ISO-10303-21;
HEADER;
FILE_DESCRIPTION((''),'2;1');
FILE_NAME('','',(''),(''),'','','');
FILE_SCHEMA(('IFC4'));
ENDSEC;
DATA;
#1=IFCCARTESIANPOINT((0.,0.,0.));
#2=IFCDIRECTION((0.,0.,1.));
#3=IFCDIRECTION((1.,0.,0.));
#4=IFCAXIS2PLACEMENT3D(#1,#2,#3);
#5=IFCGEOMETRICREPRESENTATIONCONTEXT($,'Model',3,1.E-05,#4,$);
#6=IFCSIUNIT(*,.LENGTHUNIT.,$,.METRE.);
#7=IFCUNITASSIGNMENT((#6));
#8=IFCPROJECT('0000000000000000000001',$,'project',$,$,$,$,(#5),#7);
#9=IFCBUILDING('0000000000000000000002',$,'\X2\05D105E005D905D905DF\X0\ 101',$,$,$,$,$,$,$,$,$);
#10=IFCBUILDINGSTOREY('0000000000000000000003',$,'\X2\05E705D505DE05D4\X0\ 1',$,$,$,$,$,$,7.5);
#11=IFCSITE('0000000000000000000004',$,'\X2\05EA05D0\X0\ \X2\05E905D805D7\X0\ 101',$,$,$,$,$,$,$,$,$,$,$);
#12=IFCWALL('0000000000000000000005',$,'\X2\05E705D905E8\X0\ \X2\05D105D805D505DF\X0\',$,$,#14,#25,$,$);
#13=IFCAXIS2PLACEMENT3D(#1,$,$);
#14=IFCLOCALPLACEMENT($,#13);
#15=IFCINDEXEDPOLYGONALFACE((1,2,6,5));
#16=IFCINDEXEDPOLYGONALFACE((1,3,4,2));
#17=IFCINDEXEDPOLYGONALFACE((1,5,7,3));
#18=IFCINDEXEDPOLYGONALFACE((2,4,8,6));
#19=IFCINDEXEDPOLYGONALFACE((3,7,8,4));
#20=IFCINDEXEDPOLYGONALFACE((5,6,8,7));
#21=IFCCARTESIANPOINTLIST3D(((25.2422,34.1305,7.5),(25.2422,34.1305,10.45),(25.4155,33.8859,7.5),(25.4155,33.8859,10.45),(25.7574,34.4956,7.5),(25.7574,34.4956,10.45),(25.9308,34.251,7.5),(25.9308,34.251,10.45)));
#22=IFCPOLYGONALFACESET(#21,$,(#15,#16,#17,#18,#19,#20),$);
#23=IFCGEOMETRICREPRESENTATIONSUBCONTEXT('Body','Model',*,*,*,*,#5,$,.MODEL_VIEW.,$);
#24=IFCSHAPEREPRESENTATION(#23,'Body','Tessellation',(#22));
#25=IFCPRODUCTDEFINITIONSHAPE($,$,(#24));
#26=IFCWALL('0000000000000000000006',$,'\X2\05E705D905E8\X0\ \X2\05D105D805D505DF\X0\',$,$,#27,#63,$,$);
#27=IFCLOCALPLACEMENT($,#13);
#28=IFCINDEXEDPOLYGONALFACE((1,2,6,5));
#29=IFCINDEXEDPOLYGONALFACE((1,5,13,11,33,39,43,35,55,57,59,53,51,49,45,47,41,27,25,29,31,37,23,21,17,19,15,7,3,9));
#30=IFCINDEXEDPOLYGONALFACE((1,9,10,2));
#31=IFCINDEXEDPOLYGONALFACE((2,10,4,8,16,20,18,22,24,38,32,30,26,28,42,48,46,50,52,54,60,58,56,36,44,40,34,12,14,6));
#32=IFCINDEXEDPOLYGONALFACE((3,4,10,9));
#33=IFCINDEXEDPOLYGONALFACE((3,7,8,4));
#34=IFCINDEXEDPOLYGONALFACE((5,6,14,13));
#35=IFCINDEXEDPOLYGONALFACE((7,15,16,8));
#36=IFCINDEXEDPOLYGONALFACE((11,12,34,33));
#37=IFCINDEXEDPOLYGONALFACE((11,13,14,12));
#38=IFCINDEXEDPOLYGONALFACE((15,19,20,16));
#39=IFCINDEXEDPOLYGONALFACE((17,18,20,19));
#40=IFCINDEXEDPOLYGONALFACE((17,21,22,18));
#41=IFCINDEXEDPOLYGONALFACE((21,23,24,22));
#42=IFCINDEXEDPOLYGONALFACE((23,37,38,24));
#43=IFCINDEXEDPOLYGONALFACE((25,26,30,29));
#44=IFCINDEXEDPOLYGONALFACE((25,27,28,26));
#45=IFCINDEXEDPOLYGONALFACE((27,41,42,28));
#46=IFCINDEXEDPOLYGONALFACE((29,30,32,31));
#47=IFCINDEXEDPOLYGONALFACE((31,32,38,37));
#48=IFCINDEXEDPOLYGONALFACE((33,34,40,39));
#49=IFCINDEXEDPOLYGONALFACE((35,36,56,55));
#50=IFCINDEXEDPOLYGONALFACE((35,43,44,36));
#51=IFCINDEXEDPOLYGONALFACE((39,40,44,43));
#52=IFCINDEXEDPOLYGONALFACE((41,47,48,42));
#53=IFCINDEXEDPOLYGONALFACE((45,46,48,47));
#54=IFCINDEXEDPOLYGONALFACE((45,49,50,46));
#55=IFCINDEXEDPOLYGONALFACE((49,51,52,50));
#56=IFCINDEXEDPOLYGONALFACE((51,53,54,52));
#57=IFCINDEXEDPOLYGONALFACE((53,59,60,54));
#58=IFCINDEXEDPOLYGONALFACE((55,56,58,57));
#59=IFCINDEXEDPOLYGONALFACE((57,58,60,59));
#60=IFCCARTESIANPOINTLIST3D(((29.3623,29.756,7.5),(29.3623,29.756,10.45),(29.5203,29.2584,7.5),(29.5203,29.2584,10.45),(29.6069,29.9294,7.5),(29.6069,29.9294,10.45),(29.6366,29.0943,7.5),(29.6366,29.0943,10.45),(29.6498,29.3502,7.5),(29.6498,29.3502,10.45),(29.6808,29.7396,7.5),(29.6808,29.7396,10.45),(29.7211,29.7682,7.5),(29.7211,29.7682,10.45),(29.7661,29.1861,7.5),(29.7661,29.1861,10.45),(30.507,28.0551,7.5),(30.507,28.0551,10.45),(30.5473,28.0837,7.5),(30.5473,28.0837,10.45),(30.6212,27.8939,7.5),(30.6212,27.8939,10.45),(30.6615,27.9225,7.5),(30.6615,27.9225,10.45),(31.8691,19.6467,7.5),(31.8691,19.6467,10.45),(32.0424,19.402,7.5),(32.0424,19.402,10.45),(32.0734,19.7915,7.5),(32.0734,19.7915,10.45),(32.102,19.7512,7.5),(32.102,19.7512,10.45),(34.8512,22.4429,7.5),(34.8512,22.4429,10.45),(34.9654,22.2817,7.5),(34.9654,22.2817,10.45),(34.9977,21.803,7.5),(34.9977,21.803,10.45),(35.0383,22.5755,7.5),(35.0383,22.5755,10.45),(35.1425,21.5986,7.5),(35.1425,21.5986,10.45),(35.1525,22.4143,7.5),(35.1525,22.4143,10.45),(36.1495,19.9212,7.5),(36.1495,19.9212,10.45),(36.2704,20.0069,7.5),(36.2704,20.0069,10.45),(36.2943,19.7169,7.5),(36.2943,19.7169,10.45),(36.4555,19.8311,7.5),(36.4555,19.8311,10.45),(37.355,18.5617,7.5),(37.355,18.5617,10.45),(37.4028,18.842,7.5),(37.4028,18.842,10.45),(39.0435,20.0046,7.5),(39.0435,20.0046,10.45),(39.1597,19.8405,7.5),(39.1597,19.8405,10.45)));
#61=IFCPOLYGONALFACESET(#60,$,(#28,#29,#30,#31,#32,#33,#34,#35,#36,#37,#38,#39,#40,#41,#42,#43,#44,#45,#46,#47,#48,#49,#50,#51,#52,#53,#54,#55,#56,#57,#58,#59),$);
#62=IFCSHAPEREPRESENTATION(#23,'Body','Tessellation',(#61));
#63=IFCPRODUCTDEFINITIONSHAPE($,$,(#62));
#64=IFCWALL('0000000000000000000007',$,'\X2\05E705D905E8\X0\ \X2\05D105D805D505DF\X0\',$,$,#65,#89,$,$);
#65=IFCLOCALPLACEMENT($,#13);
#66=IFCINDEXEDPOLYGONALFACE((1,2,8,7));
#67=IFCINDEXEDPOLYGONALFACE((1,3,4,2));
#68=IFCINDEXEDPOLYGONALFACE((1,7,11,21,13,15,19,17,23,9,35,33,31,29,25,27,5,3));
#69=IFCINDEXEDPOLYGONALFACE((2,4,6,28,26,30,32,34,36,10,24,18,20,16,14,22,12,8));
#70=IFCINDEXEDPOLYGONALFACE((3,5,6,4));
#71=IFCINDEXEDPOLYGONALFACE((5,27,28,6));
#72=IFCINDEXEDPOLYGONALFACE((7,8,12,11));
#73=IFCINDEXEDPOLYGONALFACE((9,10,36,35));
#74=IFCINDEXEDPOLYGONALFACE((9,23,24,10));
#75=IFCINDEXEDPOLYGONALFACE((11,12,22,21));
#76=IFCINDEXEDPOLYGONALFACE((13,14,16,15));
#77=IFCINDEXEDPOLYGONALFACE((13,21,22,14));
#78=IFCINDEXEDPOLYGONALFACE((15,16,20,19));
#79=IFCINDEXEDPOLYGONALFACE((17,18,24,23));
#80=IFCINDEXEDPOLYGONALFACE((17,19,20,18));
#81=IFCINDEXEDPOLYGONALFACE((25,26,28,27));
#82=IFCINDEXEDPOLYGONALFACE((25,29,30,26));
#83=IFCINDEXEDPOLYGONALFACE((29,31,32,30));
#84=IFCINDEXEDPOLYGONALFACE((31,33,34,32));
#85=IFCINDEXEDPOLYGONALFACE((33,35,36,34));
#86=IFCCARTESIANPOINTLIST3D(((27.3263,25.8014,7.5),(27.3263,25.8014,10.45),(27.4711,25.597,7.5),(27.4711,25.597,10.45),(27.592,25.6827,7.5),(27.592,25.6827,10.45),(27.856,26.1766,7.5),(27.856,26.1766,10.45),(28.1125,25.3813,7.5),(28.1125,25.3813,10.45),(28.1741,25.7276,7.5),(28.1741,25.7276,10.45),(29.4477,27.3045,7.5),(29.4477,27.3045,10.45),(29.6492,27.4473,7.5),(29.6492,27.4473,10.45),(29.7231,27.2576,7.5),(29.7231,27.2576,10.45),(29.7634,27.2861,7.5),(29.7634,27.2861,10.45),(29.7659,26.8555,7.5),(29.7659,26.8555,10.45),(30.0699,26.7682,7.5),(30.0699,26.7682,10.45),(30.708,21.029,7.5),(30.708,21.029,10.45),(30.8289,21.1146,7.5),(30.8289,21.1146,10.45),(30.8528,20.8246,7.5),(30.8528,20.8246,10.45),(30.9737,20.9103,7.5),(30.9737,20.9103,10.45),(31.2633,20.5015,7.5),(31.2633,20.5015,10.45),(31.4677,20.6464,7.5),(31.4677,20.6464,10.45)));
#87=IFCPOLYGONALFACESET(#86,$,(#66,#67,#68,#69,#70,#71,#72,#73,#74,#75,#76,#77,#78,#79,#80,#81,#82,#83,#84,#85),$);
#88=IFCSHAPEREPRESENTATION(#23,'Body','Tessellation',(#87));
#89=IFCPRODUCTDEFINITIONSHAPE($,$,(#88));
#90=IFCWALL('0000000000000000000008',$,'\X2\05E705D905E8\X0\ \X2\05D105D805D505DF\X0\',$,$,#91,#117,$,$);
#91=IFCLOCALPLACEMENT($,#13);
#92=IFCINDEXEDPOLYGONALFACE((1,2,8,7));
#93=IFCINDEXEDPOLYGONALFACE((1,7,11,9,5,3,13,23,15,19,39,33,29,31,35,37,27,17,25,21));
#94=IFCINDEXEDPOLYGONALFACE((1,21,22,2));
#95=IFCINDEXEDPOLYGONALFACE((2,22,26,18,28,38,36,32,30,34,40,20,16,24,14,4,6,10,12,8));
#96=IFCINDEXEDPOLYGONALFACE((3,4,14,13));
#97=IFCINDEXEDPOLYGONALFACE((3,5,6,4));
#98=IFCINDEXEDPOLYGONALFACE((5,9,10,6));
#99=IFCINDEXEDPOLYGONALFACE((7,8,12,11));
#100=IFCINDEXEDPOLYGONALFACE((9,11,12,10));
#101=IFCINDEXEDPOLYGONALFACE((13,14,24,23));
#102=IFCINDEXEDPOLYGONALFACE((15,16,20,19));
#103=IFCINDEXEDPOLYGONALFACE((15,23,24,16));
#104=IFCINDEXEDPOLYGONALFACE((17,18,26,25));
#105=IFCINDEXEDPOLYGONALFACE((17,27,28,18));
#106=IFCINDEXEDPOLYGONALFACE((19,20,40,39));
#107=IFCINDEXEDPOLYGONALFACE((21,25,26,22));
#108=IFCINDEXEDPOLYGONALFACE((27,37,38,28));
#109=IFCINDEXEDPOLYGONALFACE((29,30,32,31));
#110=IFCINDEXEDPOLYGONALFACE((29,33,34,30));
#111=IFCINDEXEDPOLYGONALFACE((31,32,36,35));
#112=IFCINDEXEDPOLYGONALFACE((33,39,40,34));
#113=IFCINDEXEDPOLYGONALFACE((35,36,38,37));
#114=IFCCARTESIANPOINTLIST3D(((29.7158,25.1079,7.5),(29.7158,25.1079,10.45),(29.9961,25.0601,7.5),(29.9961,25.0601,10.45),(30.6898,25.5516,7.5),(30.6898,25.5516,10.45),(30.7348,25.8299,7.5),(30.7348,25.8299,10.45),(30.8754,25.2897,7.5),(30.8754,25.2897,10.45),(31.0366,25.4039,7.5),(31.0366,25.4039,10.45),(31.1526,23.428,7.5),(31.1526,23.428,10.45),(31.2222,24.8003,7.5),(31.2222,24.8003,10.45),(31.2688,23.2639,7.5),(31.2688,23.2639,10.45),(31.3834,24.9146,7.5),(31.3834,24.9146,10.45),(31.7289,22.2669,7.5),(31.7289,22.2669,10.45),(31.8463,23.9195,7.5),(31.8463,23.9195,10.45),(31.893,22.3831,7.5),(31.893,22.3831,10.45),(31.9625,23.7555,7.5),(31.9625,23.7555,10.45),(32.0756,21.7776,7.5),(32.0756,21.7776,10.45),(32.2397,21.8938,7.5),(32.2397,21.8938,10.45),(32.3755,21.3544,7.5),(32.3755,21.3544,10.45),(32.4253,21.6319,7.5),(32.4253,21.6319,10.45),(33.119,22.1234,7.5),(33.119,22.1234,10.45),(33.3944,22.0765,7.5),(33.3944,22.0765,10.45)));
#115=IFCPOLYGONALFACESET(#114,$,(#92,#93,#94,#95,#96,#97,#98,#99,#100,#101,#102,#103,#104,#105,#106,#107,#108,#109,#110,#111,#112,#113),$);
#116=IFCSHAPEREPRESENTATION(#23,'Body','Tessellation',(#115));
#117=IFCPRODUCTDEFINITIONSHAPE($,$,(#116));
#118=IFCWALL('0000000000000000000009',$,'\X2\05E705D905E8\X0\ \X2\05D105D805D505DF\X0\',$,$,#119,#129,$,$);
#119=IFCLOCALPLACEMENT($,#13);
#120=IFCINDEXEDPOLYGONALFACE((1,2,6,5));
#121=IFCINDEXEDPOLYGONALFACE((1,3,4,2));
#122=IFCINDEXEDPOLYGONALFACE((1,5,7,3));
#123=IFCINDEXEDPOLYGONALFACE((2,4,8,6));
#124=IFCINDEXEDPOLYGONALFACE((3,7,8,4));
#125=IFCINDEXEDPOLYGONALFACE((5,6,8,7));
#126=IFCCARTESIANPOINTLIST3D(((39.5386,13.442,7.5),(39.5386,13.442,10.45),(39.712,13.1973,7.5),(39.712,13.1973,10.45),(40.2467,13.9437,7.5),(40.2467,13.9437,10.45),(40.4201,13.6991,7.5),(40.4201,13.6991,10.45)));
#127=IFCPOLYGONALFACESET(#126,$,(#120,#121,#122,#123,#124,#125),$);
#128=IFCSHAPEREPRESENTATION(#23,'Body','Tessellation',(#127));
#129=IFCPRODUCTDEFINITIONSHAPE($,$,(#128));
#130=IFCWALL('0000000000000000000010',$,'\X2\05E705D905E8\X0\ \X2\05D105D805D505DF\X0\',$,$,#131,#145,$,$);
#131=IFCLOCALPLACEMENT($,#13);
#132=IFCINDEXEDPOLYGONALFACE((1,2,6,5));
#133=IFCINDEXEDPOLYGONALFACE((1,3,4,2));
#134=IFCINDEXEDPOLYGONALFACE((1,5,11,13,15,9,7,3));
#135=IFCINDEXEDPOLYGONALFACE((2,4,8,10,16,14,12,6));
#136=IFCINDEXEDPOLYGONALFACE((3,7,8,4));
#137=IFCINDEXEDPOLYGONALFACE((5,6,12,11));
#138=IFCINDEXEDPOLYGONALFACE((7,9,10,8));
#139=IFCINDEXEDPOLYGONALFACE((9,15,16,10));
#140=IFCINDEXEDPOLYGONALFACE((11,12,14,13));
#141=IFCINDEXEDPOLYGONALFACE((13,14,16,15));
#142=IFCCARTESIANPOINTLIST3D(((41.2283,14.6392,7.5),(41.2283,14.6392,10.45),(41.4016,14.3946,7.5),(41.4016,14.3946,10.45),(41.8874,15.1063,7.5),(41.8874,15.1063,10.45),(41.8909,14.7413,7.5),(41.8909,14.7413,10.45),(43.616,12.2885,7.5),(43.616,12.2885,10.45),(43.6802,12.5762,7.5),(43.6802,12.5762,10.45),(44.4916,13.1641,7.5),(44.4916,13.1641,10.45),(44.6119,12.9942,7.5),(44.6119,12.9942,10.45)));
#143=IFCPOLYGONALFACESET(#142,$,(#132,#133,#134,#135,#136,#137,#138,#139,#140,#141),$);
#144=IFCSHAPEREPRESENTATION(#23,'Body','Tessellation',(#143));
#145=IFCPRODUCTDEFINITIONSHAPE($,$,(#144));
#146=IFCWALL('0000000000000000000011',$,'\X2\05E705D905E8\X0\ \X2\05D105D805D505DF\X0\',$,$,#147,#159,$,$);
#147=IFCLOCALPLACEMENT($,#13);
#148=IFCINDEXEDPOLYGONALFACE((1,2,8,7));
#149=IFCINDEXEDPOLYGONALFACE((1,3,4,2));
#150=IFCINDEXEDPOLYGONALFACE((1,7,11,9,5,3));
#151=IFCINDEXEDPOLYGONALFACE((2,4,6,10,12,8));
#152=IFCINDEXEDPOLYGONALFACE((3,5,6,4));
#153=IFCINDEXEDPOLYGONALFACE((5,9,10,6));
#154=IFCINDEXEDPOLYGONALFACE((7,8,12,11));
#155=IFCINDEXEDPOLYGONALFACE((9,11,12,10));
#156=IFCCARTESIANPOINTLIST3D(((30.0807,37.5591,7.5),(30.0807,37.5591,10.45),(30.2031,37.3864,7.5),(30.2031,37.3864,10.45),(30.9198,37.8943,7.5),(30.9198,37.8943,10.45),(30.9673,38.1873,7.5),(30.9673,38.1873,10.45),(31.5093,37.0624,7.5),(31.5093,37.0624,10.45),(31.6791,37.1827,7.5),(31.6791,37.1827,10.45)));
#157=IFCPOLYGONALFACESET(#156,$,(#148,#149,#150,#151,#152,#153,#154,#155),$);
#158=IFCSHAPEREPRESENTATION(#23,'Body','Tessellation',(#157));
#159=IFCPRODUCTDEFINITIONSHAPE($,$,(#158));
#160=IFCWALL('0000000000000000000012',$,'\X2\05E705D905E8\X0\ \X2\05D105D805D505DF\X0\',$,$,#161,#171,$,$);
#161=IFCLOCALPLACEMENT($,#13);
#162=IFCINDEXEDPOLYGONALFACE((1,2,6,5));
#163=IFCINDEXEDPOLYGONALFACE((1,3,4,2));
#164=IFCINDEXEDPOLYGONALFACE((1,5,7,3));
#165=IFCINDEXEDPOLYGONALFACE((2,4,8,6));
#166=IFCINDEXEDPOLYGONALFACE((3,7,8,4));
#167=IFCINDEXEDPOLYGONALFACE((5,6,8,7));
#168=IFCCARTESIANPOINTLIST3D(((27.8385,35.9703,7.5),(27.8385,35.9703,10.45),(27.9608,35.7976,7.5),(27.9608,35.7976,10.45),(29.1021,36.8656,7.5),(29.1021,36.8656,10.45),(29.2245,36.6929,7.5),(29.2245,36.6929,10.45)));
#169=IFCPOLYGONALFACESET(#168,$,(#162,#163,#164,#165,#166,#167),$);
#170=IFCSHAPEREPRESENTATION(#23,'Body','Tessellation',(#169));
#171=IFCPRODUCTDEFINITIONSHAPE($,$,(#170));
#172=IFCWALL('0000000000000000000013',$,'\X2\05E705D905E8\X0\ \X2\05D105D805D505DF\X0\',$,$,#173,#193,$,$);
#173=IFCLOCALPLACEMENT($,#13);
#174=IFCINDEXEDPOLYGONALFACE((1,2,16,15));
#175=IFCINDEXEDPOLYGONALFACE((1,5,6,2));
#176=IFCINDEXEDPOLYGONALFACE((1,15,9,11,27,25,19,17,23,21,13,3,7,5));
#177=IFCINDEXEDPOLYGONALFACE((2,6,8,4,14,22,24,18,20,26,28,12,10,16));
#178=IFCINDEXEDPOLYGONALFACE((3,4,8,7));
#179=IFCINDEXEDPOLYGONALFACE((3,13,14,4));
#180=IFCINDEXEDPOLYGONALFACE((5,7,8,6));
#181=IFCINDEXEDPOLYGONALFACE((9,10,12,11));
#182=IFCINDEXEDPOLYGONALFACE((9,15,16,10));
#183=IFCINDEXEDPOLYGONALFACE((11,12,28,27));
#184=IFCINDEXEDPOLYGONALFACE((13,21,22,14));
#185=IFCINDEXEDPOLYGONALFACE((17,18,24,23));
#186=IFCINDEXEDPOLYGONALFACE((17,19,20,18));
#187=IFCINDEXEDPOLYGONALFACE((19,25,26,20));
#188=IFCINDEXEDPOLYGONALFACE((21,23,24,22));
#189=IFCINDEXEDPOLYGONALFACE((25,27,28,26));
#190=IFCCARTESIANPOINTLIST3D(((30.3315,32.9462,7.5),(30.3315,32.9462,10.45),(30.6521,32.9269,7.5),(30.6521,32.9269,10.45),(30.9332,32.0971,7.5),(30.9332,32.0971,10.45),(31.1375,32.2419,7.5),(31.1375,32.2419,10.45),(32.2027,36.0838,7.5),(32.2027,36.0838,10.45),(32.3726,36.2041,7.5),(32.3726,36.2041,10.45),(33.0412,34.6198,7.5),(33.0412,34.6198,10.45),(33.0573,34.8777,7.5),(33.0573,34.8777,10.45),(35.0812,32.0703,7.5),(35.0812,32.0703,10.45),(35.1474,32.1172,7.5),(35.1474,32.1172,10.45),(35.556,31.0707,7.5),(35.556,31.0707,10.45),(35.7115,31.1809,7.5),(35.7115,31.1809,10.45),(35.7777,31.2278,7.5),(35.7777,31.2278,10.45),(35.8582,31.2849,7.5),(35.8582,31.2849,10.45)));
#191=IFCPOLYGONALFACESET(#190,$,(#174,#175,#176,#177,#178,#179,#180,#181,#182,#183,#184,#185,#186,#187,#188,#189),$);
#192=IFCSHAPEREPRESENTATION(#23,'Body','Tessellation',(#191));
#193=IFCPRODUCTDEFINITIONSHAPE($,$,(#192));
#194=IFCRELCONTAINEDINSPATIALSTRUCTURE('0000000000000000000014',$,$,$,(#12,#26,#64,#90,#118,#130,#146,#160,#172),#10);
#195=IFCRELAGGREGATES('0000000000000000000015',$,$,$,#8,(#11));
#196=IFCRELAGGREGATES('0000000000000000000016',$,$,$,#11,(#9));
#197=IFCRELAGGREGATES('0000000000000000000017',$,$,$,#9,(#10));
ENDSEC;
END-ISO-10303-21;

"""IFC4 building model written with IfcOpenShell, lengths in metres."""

from ifc_helpers import new_model, si_unit, frame, origin_with_axes, context, subcontext, project, spatial, polyline, outline, extrude, element, save


model = new_model("IFC4")

# Units and contexts
model_context = context("Model", 3, precision=1e-05, world=origin_with_axes())
body_context = subcontext(model_context, "Body", "Model", "MODEL_VIEW")
ifc_project = project(units=[si_unit("LENGTHUNIT", "METRE")], contexts=[model_context])

# Site, building, storey
site = spatial("IfcSite", under=ifc_project, Name="תא שטח 101")
building = spatial("IfcBuilding", under=site, Name="בניין 101")
storey = spatial("IfcBuildingStorey", under=building, Name="קומה 1", Elevation=7.5)

# Walls
element("IfcWall", 1, inside=storey, Name="קיר בטון", context=body_context, shape_type="SweptSolid", body=[
    extrude(outline(polyline([(25.7574, 34.4956), (25.2422, 34.1305), (25.4155, 33.8859), (25.9308, 34.251), (25.7574, 34.4956)])), frame((0.0, 0.0, 7.5)), (0.0, 0.0, 1.0), 2.95),
])
element("IfcWall", 2, inside=storey, Name="קיר בטון", context=body_context, shape_type="SweptSolid", body=[
    extrude(outline(polyline([(29.6069, 29.9294), (29.3623, 29.756), (29.6498, 29.3502), (29.5203, 29.2584), (29.6366, 29.0943), (29.7661, 29.1861), (30.5473, 28.0837), (30.507, 28.0551), (30.6212, 27.8939), (30.6615, 27.9225), (34.9977, 21.803), (32.102, 19.7512), (32.0734, 19.7915), (31.8691, 19.6467), (32.0424, 19.402), (35.1425, 21.5986), (36.2704, 20.0069), (36.1495, 19.9212), (36.2943, 19.7169), (36.4555, 19.8311), (37.355, 18.5617), (39.1597, 19.8405), (39.0435, 20.0046), (37.4028, 18.842), (34.9654, 22.2817), (35.1525, 22.4143), (35.0383, 22.5755), (34.8512, 22.4429), (29.6808, 29.7396), (29.7211, 29.7682), (29.6069, 29.9294)])), frame((0.0, 0.0, 7.5)), (0.0, 0.0, 1.0), 2.95),
])
element("IfcWall", 3, inside=storey, Name="קיר בטון", context=body_context, shape_type="SweptSolid", body=[
    extrude(outline(polyline([(28.1741, 25.7276), (27.856, 26.1766), (27.3263, 25.8014), (27.4711, 25.597), (27.592, 25.6827), (30.8289, 21.1146), (30.708, 21.029), (30.8528, 20.8246), (30.9737, 20.9103), (31.2633, 20.5015), (31.4677, 20.6464), (28.1125, 25.3813), (30.0699, 26.7682), (29.7231, 27.2576), (29.7634, 27.2861), (29.6492, 27.4473), (29.4477, 27.3045), (29.7659, 26.8555), (28.1741, 25.7276)])), frame((0.0, 0.0, 7.5)), (0.0, 0.0, 1.0), 2.95),
])
element("IfcWall", 4, inside=storey, Name="קיר בטון", context=body_context, shape_type="SweptSolid", body=[
    extrude(outline(polyline([(29.7158, 25.1079), (31.7289, 22.2669), (31.893, 22.3831), (31.2688, 23.2639), (31.9625, 23.7555), (33.119, 22.1234), (32.4253, 21.6319), (32.2397, 21.8938), (32.0756, 21.7776), (32.3755, 21.3544), (33.3944, 22.0765), (31.3834, 24.9146), (31.2222, 24.8003), (31.8463, 23.9195), (31.1526, 23.428), (29.9961, 25.0601), (30.6898, 25.5516), (30.8754, 25.2897), (31.0366, 25.4039), (30.7348, 25.8299), (29.7158, 25.1079)])), frame((0.0, 0.0, 7.5)), (0.0, 0.0, 1.0), 2.95),
])
element("IfcWall", 5, inside=storey, Name="קיר בטון", context=body_context, shape_type="SweptSolid", body=[
    extrude(outline(polyline([(39.712, 13.1973), (40.4201, 13.6991), (40.2467, 13.9437), (39.5386, 13.442), (39.712, 13.1973)])), frame((0.0, 0.0, 7.5)), (0.0, 0.0, 1.0), 2.95),
])
element("IfcWall", 6, inside=storey, Name="קיר בטון", context=body_context, shape_type="SweptSolid", body=[
    extrude(outline(polyline([(41.8909, 14.7413), (43.616, 12.2885), (44.6119, 12.9942), (44.4916, 13.1641), (43.6802, 12.5762), (41.8874, 15.1063), (41.2283, 14.6392), (41.4016, 14.3946), (41.8909, 14.7413)])), frame((0.0, 0.0, 7.5)), (0.0, 0.0, 1.0), 2.95),
])
element("IfcWall", 7, inside=storey, Name="קיר בטון", context=body_context, shape_type="SweptSolid", body=[
    extrude(outline(polyline([(31.5093, 37.0624), (31.6791, 37.1827), (30.9673, 38.1873), (30.0807, 37.5591), (30.2031, 37.3864), (30.9198, 37.8943), (31.5093, 37.0624)])), frame((0.0, 0.0, 7.5)), (0.0, 0.0, 1.0), 2.95),
])
element("IfcWall", 8, inside=storey, Name="קיר בטון", context=body_context, shape_type="SweptSolid", body=[
    extrude(outline(polyline([(29.2245, 36.6929), (29.1021, 36.8656), (27.8385, 35.9703), (27.9608, 35.7976), (29.2245, 36.6929)])), frame((0.0, 0.0, 7.5)), (0.0, 0.0, 1.0), 2.95),
])
element("IfcWall", 9, inside=storey, Name="קיר בטון", context=body_context, shape_type="SweptSolid", body=[
    extrude(outline(polyline([(33.0573, 34.8777), (30.3315, 32.9462), (30.9332, 32.0971), (31.1375, 32.2419), (30.6521, 32.9269), (33.0412, 34.6198), (35.556, 31.0707), (35.7115, 31.1809), (35.0812, 32.0703), (35.1474, 32.1172), (35.7777, 31.2278), (35.8582, 31.2849), (32.3726, 36.2041), (32.2027, 36.0838), (33.0573, 34.8777)])), frame((0.0, 0.0, 7.5)), (0.0, 0.0, 1.0), 2.95),
])

save(model, "model.ifc")
